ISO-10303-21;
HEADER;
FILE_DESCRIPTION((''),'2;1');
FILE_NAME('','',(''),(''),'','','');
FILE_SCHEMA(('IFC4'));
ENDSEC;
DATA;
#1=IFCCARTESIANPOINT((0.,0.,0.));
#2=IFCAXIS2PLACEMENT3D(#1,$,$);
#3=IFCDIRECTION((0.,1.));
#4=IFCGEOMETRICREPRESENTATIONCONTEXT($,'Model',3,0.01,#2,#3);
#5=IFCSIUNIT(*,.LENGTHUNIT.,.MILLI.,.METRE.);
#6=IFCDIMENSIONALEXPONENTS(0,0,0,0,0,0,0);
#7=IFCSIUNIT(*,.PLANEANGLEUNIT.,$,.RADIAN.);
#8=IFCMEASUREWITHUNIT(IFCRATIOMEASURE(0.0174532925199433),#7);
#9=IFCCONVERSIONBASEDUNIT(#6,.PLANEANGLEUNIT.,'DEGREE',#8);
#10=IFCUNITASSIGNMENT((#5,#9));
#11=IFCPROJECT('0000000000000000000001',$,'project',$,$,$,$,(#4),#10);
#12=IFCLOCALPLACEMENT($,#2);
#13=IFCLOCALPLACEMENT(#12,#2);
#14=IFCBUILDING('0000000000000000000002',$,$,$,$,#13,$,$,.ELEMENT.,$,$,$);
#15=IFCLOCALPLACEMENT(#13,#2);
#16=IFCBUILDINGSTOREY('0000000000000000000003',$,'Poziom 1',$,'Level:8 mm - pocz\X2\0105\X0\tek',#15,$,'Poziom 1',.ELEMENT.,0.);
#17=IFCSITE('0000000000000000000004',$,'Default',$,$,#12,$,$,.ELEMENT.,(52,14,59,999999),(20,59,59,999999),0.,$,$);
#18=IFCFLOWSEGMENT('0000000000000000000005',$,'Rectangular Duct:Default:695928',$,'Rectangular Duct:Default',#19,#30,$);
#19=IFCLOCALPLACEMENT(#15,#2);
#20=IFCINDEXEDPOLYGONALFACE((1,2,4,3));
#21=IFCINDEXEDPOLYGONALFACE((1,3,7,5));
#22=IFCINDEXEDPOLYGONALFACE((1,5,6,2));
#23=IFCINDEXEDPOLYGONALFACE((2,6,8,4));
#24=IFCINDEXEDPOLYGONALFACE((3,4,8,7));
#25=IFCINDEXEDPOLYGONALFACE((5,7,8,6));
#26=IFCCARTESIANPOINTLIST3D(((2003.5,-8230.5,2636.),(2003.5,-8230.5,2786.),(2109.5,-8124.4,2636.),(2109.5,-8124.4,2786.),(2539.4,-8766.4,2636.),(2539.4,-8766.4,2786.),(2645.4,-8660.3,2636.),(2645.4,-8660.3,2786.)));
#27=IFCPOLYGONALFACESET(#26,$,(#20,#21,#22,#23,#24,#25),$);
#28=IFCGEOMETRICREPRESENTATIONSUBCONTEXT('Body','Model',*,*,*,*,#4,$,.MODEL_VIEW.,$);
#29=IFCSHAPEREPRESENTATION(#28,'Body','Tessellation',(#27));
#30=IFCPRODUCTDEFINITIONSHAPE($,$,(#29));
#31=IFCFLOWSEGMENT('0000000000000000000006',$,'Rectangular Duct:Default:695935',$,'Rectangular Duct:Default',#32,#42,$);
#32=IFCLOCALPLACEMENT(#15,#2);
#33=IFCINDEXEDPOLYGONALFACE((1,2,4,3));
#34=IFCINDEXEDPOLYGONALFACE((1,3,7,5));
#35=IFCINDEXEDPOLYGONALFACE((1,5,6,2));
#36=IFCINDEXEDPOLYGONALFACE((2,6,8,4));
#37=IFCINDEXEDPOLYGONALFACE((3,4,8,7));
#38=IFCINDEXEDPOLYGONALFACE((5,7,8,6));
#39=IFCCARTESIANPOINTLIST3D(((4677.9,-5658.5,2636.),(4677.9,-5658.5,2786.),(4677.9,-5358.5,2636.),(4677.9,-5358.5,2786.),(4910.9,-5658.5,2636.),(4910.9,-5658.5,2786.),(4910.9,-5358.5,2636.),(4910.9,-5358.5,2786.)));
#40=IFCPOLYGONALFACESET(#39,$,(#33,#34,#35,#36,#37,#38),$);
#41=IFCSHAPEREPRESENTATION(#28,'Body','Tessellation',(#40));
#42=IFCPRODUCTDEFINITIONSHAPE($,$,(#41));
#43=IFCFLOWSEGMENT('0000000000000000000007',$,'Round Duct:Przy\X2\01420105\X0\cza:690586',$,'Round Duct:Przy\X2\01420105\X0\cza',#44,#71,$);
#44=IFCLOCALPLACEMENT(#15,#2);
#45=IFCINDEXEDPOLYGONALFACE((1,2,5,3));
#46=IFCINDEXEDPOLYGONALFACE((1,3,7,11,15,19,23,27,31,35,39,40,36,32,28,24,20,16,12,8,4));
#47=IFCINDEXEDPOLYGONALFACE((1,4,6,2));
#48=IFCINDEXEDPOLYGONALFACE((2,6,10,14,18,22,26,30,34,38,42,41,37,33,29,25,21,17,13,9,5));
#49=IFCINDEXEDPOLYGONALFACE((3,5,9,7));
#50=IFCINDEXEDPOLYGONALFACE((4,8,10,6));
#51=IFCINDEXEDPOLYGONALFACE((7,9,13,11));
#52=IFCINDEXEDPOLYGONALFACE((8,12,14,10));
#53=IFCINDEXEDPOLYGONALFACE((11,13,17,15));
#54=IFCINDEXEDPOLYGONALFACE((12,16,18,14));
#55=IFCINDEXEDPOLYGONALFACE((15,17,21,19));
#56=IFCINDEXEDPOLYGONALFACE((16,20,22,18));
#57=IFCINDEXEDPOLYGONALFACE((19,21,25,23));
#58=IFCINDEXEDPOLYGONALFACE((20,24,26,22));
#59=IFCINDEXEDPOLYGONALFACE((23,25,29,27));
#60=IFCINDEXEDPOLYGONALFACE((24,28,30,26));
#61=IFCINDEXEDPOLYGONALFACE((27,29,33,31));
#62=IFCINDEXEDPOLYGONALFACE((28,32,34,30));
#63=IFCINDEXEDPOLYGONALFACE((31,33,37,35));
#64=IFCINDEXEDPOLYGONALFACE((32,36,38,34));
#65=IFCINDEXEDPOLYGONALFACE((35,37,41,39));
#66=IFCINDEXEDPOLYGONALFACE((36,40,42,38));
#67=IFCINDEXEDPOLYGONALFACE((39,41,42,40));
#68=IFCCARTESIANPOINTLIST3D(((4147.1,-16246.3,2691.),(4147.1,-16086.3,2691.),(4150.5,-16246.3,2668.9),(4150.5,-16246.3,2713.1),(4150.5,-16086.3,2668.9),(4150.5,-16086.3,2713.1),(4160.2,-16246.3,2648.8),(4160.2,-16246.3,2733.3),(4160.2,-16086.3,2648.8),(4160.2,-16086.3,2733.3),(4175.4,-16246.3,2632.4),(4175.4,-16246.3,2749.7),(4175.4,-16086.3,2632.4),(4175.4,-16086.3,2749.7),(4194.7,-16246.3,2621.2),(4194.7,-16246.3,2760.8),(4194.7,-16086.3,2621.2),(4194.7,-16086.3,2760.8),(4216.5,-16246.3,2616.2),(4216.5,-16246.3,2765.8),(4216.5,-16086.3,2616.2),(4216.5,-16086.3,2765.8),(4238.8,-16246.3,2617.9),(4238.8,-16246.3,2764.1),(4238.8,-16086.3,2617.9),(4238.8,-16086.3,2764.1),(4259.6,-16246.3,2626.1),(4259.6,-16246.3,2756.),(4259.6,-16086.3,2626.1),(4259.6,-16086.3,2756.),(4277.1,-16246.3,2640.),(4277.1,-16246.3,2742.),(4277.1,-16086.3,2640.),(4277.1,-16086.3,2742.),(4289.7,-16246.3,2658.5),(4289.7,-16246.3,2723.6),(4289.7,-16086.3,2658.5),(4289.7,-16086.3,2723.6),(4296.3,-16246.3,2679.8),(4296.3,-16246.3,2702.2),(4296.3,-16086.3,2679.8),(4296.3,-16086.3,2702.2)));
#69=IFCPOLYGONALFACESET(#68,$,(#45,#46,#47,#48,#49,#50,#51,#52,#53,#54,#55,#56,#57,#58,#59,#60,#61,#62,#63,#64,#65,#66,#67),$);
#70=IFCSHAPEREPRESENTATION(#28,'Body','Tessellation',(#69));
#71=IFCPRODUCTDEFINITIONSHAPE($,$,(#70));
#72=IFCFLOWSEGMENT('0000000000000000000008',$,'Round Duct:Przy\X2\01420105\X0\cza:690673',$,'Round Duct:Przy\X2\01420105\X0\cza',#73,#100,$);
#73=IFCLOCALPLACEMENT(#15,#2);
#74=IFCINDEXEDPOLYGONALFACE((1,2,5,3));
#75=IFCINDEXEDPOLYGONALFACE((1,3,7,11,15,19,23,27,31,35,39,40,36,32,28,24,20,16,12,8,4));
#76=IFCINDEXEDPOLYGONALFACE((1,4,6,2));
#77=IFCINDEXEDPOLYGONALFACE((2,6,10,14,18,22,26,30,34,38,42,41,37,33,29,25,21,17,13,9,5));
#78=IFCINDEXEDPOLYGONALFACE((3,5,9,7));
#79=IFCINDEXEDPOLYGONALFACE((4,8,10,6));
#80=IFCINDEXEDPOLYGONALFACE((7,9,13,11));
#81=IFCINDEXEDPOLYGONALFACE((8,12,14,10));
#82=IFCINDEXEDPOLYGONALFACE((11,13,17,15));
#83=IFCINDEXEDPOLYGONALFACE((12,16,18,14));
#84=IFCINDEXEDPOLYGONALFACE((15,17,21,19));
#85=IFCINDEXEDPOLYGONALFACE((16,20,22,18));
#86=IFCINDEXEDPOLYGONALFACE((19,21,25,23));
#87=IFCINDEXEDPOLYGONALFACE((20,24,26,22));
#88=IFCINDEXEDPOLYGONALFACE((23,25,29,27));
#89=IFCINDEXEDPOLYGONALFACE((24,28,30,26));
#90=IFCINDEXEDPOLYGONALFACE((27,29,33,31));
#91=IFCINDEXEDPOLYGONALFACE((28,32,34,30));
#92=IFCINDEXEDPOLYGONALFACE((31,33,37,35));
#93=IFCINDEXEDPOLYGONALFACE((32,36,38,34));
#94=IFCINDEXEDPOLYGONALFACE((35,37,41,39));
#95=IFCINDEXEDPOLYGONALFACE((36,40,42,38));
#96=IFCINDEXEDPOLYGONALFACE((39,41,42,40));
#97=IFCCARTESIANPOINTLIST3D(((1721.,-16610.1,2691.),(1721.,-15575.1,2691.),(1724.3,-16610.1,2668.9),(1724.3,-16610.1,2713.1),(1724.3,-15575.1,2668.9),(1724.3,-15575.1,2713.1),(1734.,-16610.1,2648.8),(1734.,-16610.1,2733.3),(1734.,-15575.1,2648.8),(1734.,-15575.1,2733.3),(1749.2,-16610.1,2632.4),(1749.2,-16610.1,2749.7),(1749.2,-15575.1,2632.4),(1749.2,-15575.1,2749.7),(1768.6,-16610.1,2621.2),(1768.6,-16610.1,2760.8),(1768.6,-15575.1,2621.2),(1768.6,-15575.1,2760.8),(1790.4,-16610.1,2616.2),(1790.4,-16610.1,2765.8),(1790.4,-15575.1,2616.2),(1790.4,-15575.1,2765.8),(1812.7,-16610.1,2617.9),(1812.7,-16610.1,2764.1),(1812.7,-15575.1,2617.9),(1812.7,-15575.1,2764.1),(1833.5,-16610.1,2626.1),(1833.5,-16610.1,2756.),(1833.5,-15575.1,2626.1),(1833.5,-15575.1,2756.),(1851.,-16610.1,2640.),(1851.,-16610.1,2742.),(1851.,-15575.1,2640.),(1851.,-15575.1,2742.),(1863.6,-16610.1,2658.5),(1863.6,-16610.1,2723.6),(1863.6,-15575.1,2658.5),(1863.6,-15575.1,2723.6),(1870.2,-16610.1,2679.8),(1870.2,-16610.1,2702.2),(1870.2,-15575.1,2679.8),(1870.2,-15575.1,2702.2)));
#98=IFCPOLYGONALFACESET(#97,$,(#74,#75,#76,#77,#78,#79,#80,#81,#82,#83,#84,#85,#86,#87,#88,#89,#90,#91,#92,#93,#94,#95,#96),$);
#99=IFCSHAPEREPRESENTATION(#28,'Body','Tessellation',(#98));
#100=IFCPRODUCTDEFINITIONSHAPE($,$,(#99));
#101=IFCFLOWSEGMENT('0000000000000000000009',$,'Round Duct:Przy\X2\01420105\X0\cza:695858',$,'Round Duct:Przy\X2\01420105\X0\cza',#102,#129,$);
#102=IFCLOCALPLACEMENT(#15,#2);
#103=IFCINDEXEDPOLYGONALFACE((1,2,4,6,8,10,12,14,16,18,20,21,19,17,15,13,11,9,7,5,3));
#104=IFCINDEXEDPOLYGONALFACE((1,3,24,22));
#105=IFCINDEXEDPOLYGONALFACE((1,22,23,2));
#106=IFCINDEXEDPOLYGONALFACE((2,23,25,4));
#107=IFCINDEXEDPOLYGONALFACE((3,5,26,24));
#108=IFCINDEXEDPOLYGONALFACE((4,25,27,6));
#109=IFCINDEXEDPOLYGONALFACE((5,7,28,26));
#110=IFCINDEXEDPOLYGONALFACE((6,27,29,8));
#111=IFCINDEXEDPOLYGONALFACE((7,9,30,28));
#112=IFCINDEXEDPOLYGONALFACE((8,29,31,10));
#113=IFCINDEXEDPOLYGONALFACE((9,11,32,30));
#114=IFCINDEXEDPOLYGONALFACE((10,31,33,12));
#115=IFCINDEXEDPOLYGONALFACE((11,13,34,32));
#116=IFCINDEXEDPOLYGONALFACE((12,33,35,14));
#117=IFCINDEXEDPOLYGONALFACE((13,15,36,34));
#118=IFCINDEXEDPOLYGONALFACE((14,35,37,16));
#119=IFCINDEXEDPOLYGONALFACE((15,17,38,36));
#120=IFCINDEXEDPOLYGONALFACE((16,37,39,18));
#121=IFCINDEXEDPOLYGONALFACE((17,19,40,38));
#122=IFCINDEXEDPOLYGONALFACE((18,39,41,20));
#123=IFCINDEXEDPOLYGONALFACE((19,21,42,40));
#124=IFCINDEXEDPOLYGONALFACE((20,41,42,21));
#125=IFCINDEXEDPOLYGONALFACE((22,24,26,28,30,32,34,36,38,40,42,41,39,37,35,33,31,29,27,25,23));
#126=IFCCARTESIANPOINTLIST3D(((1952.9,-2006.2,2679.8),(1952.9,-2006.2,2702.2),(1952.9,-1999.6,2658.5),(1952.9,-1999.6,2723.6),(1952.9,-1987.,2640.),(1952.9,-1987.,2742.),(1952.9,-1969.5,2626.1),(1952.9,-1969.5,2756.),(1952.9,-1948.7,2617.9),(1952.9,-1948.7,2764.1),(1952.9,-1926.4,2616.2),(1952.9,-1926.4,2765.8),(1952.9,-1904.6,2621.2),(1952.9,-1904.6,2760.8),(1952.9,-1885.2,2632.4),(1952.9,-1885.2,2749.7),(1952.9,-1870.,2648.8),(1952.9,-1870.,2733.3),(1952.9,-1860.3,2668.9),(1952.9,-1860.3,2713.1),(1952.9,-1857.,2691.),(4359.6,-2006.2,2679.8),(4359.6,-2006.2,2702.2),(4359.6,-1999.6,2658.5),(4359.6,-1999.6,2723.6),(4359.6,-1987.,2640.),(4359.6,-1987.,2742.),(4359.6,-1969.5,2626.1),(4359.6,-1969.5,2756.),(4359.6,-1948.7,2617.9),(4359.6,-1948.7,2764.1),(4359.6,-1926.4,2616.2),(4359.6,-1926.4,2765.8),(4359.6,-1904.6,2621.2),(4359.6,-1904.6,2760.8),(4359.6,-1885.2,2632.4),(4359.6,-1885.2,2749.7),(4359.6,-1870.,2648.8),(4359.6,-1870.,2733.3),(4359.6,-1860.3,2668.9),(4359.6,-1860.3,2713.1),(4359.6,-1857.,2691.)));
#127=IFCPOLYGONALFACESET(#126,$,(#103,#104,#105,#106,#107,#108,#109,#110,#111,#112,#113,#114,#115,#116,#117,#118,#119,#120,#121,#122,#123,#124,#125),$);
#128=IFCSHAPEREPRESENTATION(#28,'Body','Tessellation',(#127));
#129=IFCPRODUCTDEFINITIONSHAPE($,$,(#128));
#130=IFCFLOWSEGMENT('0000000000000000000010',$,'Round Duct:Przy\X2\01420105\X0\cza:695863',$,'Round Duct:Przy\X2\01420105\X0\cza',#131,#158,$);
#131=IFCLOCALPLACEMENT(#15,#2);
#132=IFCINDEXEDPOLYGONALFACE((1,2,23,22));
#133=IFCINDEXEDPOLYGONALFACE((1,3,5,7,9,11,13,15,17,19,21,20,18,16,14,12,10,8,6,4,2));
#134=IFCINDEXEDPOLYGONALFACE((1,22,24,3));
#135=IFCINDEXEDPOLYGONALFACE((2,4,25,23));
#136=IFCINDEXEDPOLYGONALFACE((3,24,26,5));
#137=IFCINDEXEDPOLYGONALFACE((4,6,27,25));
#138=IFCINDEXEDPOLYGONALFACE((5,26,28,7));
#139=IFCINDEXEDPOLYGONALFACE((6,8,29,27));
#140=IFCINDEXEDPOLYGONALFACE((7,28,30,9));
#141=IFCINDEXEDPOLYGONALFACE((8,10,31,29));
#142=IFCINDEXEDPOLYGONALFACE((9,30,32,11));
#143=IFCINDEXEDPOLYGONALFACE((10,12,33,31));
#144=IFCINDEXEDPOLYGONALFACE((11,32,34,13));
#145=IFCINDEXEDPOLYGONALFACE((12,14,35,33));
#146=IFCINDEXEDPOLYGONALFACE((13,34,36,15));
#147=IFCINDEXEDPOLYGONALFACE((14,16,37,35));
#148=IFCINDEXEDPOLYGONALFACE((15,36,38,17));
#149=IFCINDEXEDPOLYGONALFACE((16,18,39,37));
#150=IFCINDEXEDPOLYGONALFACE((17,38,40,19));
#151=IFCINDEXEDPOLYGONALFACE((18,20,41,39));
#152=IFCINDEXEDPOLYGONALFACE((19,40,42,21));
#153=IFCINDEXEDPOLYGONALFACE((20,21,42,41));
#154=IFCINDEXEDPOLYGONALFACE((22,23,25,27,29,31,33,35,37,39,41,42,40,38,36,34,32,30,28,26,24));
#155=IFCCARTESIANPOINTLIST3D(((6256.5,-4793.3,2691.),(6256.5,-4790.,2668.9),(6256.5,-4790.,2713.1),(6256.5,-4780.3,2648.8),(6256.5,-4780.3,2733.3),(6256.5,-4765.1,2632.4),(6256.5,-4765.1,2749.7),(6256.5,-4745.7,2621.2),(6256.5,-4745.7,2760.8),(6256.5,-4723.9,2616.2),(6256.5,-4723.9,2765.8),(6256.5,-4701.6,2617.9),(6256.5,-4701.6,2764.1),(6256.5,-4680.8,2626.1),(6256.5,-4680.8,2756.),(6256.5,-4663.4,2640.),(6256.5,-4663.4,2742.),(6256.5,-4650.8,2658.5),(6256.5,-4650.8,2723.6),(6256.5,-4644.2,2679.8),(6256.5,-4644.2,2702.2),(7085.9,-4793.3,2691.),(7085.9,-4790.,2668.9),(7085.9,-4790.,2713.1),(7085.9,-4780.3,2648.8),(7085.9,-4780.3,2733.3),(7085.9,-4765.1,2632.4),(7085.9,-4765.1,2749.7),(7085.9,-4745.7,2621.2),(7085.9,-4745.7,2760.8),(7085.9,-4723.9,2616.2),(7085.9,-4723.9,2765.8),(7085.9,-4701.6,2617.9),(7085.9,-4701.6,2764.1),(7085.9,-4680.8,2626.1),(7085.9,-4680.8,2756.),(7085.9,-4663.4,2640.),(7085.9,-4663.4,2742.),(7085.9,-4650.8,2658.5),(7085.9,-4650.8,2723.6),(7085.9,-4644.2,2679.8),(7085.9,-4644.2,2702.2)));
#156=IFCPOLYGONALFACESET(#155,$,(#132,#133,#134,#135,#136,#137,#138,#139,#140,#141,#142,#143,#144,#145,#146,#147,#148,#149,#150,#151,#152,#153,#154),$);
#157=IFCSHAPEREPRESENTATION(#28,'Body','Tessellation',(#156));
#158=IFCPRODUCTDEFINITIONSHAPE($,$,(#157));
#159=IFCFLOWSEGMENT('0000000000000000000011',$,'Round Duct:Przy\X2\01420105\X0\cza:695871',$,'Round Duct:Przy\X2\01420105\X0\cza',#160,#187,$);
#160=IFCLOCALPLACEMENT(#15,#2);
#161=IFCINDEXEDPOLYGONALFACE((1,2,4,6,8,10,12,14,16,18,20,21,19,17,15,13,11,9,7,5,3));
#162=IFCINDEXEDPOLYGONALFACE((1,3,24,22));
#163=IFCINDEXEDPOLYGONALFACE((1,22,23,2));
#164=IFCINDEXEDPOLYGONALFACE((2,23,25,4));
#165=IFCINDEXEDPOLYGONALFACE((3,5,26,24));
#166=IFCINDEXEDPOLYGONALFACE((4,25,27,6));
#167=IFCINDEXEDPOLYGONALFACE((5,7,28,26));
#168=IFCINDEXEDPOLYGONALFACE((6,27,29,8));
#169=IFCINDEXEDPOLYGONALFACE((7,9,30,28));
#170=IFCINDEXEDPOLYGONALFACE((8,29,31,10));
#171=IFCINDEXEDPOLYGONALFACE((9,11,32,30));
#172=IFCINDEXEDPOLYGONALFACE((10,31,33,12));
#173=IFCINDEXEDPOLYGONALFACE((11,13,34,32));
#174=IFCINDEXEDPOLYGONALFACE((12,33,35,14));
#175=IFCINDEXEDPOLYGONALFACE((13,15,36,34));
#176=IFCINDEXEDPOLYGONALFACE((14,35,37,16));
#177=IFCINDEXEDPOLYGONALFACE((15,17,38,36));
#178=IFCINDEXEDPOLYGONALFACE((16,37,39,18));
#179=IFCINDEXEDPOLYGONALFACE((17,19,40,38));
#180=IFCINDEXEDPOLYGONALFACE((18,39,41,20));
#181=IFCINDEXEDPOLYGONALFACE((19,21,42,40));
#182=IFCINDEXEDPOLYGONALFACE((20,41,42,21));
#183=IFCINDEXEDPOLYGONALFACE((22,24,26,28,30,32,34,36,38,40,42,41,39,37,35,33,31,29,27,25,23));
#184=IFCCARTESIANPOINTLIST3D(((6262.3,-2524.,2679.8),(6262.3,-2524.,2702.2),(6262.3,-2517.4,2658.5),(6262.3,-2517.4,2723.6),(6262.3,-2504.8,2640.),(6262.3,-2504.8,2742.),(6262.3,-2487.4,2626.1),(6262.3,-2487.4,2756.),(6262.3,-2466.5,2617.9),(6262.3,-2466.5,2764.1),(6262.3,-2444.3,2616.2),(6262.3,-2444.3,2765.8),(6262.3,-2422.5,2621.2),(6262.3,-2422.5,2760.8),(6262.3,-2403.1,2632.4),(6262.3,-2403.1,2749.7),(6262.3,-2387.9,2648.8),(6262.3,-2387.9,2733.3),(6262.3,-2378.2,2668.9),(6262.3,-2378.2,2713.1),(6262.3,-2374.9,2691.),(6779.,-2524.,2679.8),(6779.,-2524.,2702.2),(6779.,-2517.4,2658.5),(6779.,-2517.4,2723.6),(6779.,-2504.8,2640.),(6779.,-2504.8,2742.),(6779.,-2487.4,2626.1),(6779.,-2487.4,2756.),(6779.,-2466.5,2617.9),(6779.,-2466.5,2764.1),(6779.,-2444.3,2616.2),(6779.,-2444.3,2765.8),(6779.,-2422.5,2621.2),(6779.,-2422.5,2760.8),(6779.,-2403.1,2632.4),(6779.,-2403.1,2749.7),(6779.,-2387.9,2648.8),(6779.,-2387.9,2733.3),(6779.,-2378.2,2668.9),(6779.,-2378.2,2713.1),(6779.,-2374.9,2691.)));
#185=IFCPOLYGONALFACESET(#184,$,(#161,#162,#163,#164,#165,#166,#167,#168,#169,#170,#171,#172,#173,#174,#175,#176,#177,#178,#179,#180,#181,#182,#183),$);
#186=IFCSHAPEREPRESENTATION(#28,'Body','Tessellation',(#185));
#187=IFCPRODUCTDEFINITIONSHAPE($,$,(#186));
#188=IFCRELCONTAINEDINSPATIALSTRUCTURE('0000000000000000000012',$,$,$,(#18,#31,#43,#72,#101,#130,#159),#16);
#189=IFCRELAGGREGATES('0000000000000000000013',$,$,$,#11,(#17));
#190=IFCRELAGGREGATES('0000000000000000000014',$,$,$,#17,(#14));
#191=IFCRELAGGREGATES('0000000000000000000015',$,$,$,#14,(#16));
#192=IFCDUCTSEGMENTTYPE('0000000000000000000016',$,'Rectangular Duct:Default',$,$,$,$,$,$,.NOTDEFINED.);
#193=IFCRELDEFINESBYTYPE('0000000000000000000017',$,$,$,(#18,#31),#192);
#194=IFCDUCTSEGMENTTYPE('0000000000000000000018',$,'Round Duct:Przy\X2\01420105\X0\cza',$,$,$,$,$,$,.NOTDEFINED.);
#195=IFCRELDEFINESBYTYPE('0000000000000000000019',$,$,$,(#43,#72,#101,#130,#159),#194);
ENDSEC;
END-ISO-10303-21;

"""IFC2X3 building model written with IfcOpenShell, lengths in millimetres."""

from ifc_helpers import new_model, entity, si_unit, converted_unit, direction, frame, frame_2d, origin, place, context, subcontext, project, spatial, rectangle, circle, extrude, type_object, element, save


model = new_model("IFC2X3")

# Units and contexts
model_context = context("Model", 3, precision=0.01, world=origin(), true_north=direction((0.0, 1.0)))
body_context = subcontext(model_context, "Body", "Model", "MODEL_VIEW")
ifc_project = project(units=[si_unit("LENGTHUNIT", "METRE", prefix="MILLI"), converted_unit("PLANEANGLEUNIT", "DEGREE", entity("IfcRatioMeasure", 0.0174532925199433), si_unit("PLANEANGLEUNIT", "RADIAN"), dimensions=[0, 0, 0, 0, 0, 0, 0])], contexts=[model_context])

# Site, building, storey
site_placement = place(None, origin())
site = spatial("IfcSite", under=ifc_project, at=site_placement, Name="Default", CompositionType="ELEMENT", RefLatitude=(52, 14, 59, 999999), RefLongitude=(20, 59, 59, 999999), RefElevation=0.0)
building_placement = place(site_placement, origin())
building = spatial("IfcBuilding", under=site, at=building_placement, CompositionType="ELEMENT")
storey_placement = place(building_placement, origin())
storey = spatial("IfcBuildingStorey", under=building, at=storey_placement, Name="Poziom 1", ObjectType="Level:8 mm - początek", LongName="Poziom 1", CompositionType="ELEMENT", Elevation=0.0)

# Flow segments
duct_segment_type_1 = type_object("IfcDuctSegmentType", Name="Rectangular Duct:Default", PredefinedType="NOTDEFINED")
flow_segment_1_placement = place(storey_placement, origin())
element("IfcFlowSegment", 1, at=flow_segment_1_placement, inside=storey, type_object=duct_segment_type_1, Name="Rectangular Duct:Default:695928", ObjectType="Rectangular Duct:Default", context=body_context, shape_type="SweptSolid", body=[
    extrude(rectangle(XDim=757.9, YDim=150.0, at=frame_2d((0.0, 0.0), x_axis=(1.0, 0.0))), frame((2324.4, -8445.4, 2636.0), z_axis=(0.0, 0.0, 1.0), x_axis=(0.707107, -0.707107, 0.0)), (0.0, 0.0, 1.0), 150.0),
])
flow_segment_2_placement = place(storey_placement, origin())
element("IfcFlowSegment", 2, at=flow_segment_2_placement, inside=storey, type_object=duct_segment_type_1, Name="Rectangular Duct:Default:695935", ObjectType="Rectangular Duct:Default", context=body_context, shape_type="SweptSolid", body=[
    extrude(rectangle(XDim=233.1, YDim=300.0, at=frame_2d((0.0, 0.0), x_axis=(1.0, 0.0))), frame((4794.4, -5508.5, 2636.0), z_axis=(0.0, 0.0, 1.0), x_axis=(-1.0, 0.0, 0.0)), (0.0, 0.0, 1.0), 150.0),
])
duct_segment_type_2 = type_object("IfcDuctSegmentType", Name="Round Duct:Przyłącza", PredefinedType="NOTDEFINED")
flow_segment_3_placement = place(storey_placement, origin())
element("IfcFlowSegment", 3, at=flow_segment_3_placement, inside=storey, type_object=duct_segment_type_2, Name="Round Duct:Przyłącza:690586", ObjectType="Round Duct:Przyłącza", context=body_context, shape_type="SweptSolid", body=[
    extrude(circle(Radius=75.0, at=frame_2d((0.0, 0.0), x_axis=(1.0, 0.0))), frame((4222.1, -16246.3, 2691.0), z_axis=(0.0, 1.0, 0.0), x_axis=(-1.0, 0.0, 0.0)), (0.0, 0.0, 1.0), 160.0),
])
flow_segment_4_placement = place(storey_placement, origin())
element("IfcFlowSegment", 4, at=flow_segment_4_placement, inside=storey, type_object=duct_segment_type_2, Name="Round Duct:Przyłącza:690673", ObjectType="Round Duct:Przyłącza", context=body_context, shape_type="SweptSolid", body=[
    extrude(circle(Radius=75.0, at=frame_2d((0.0, 0.0), x_axis=(1.0, 0.0))), frame((1796.0, -16610.1, 2691.0), z_axis=(0.0, 1.0, 0.0), x_axis=(-1.0, 0.0, 0.0)), (0.0, 0.0, 1.0), 1035.0),
])
flow_segment_5_placement = place(storey_placement, origin())
element("IfcFlowSegment", 5, at=flow_segment_5_placement, inside=storey, type_object=duct_segment_type_2, Name="Round Duct:Przyłącza:695858", ObjectType="Round Duct:Przyłącza", context=body_context, shape_type="SweptSolid", body=[
    extrude(circle(Radius=75.0, at=frame_2d((0.0, 0.0), x_axis=(1.0, 0.0))), frame((1952.9, -1932.0, 2691.0), z_axis=(1.0, 0.0, 0.0), x_axis=(0.0, 1.0, 0.0)), (0.0, 0.0, 1.0), 2406.7),
])
flow_segment_6_placement = place(storey_placement, origin())
element("IfcFlowSegment", 6, at=flow_segment_6_placement, inside=storey, type_object=duct_segment_type_2, Name="Round Duct:Przyłącza:695863", ObjectType="Round Duct:Przyłącza", context=body_context, shape_type="SweptSolid", body=[
    extrude(circle(Radius=75.0, at=frame_2d((0.0, 0.0), x_axis=(1.0, 0.0))), frame((6256.5, -4718.3, 2691.0), z_axis=(1.0, 0.0, 0.0), x_axis=(0.0, -1.0, 0.0)), (0.0, 0.0, 1.0), 829.4),
])
flow_segment_7_placement = place(storey_placement, origin())
element("IfcFlowSegment", 7, at=flow_segment_7_placement, inside=storey, type_object=duct_segment_type_2, Name="Round Duct:Przyłącza:695871", ObjectType="Round Duct:Przyłącza", context=body_context, shape_type="SweptSolid", body=[
    extrude(circle(Radius=75.0, at=frame_2d((0.0, 0.0), x_axis=(1.0, 0.0))), frame((6262.3, -2449.9, 2691.0), z_axis=(1.0, 0.0, 0.0), x_axis=(0.0, 1.0, 0.0)), (0.0, 0.0, 1.0), 516.7),
])

save(model, "model.ifc")
